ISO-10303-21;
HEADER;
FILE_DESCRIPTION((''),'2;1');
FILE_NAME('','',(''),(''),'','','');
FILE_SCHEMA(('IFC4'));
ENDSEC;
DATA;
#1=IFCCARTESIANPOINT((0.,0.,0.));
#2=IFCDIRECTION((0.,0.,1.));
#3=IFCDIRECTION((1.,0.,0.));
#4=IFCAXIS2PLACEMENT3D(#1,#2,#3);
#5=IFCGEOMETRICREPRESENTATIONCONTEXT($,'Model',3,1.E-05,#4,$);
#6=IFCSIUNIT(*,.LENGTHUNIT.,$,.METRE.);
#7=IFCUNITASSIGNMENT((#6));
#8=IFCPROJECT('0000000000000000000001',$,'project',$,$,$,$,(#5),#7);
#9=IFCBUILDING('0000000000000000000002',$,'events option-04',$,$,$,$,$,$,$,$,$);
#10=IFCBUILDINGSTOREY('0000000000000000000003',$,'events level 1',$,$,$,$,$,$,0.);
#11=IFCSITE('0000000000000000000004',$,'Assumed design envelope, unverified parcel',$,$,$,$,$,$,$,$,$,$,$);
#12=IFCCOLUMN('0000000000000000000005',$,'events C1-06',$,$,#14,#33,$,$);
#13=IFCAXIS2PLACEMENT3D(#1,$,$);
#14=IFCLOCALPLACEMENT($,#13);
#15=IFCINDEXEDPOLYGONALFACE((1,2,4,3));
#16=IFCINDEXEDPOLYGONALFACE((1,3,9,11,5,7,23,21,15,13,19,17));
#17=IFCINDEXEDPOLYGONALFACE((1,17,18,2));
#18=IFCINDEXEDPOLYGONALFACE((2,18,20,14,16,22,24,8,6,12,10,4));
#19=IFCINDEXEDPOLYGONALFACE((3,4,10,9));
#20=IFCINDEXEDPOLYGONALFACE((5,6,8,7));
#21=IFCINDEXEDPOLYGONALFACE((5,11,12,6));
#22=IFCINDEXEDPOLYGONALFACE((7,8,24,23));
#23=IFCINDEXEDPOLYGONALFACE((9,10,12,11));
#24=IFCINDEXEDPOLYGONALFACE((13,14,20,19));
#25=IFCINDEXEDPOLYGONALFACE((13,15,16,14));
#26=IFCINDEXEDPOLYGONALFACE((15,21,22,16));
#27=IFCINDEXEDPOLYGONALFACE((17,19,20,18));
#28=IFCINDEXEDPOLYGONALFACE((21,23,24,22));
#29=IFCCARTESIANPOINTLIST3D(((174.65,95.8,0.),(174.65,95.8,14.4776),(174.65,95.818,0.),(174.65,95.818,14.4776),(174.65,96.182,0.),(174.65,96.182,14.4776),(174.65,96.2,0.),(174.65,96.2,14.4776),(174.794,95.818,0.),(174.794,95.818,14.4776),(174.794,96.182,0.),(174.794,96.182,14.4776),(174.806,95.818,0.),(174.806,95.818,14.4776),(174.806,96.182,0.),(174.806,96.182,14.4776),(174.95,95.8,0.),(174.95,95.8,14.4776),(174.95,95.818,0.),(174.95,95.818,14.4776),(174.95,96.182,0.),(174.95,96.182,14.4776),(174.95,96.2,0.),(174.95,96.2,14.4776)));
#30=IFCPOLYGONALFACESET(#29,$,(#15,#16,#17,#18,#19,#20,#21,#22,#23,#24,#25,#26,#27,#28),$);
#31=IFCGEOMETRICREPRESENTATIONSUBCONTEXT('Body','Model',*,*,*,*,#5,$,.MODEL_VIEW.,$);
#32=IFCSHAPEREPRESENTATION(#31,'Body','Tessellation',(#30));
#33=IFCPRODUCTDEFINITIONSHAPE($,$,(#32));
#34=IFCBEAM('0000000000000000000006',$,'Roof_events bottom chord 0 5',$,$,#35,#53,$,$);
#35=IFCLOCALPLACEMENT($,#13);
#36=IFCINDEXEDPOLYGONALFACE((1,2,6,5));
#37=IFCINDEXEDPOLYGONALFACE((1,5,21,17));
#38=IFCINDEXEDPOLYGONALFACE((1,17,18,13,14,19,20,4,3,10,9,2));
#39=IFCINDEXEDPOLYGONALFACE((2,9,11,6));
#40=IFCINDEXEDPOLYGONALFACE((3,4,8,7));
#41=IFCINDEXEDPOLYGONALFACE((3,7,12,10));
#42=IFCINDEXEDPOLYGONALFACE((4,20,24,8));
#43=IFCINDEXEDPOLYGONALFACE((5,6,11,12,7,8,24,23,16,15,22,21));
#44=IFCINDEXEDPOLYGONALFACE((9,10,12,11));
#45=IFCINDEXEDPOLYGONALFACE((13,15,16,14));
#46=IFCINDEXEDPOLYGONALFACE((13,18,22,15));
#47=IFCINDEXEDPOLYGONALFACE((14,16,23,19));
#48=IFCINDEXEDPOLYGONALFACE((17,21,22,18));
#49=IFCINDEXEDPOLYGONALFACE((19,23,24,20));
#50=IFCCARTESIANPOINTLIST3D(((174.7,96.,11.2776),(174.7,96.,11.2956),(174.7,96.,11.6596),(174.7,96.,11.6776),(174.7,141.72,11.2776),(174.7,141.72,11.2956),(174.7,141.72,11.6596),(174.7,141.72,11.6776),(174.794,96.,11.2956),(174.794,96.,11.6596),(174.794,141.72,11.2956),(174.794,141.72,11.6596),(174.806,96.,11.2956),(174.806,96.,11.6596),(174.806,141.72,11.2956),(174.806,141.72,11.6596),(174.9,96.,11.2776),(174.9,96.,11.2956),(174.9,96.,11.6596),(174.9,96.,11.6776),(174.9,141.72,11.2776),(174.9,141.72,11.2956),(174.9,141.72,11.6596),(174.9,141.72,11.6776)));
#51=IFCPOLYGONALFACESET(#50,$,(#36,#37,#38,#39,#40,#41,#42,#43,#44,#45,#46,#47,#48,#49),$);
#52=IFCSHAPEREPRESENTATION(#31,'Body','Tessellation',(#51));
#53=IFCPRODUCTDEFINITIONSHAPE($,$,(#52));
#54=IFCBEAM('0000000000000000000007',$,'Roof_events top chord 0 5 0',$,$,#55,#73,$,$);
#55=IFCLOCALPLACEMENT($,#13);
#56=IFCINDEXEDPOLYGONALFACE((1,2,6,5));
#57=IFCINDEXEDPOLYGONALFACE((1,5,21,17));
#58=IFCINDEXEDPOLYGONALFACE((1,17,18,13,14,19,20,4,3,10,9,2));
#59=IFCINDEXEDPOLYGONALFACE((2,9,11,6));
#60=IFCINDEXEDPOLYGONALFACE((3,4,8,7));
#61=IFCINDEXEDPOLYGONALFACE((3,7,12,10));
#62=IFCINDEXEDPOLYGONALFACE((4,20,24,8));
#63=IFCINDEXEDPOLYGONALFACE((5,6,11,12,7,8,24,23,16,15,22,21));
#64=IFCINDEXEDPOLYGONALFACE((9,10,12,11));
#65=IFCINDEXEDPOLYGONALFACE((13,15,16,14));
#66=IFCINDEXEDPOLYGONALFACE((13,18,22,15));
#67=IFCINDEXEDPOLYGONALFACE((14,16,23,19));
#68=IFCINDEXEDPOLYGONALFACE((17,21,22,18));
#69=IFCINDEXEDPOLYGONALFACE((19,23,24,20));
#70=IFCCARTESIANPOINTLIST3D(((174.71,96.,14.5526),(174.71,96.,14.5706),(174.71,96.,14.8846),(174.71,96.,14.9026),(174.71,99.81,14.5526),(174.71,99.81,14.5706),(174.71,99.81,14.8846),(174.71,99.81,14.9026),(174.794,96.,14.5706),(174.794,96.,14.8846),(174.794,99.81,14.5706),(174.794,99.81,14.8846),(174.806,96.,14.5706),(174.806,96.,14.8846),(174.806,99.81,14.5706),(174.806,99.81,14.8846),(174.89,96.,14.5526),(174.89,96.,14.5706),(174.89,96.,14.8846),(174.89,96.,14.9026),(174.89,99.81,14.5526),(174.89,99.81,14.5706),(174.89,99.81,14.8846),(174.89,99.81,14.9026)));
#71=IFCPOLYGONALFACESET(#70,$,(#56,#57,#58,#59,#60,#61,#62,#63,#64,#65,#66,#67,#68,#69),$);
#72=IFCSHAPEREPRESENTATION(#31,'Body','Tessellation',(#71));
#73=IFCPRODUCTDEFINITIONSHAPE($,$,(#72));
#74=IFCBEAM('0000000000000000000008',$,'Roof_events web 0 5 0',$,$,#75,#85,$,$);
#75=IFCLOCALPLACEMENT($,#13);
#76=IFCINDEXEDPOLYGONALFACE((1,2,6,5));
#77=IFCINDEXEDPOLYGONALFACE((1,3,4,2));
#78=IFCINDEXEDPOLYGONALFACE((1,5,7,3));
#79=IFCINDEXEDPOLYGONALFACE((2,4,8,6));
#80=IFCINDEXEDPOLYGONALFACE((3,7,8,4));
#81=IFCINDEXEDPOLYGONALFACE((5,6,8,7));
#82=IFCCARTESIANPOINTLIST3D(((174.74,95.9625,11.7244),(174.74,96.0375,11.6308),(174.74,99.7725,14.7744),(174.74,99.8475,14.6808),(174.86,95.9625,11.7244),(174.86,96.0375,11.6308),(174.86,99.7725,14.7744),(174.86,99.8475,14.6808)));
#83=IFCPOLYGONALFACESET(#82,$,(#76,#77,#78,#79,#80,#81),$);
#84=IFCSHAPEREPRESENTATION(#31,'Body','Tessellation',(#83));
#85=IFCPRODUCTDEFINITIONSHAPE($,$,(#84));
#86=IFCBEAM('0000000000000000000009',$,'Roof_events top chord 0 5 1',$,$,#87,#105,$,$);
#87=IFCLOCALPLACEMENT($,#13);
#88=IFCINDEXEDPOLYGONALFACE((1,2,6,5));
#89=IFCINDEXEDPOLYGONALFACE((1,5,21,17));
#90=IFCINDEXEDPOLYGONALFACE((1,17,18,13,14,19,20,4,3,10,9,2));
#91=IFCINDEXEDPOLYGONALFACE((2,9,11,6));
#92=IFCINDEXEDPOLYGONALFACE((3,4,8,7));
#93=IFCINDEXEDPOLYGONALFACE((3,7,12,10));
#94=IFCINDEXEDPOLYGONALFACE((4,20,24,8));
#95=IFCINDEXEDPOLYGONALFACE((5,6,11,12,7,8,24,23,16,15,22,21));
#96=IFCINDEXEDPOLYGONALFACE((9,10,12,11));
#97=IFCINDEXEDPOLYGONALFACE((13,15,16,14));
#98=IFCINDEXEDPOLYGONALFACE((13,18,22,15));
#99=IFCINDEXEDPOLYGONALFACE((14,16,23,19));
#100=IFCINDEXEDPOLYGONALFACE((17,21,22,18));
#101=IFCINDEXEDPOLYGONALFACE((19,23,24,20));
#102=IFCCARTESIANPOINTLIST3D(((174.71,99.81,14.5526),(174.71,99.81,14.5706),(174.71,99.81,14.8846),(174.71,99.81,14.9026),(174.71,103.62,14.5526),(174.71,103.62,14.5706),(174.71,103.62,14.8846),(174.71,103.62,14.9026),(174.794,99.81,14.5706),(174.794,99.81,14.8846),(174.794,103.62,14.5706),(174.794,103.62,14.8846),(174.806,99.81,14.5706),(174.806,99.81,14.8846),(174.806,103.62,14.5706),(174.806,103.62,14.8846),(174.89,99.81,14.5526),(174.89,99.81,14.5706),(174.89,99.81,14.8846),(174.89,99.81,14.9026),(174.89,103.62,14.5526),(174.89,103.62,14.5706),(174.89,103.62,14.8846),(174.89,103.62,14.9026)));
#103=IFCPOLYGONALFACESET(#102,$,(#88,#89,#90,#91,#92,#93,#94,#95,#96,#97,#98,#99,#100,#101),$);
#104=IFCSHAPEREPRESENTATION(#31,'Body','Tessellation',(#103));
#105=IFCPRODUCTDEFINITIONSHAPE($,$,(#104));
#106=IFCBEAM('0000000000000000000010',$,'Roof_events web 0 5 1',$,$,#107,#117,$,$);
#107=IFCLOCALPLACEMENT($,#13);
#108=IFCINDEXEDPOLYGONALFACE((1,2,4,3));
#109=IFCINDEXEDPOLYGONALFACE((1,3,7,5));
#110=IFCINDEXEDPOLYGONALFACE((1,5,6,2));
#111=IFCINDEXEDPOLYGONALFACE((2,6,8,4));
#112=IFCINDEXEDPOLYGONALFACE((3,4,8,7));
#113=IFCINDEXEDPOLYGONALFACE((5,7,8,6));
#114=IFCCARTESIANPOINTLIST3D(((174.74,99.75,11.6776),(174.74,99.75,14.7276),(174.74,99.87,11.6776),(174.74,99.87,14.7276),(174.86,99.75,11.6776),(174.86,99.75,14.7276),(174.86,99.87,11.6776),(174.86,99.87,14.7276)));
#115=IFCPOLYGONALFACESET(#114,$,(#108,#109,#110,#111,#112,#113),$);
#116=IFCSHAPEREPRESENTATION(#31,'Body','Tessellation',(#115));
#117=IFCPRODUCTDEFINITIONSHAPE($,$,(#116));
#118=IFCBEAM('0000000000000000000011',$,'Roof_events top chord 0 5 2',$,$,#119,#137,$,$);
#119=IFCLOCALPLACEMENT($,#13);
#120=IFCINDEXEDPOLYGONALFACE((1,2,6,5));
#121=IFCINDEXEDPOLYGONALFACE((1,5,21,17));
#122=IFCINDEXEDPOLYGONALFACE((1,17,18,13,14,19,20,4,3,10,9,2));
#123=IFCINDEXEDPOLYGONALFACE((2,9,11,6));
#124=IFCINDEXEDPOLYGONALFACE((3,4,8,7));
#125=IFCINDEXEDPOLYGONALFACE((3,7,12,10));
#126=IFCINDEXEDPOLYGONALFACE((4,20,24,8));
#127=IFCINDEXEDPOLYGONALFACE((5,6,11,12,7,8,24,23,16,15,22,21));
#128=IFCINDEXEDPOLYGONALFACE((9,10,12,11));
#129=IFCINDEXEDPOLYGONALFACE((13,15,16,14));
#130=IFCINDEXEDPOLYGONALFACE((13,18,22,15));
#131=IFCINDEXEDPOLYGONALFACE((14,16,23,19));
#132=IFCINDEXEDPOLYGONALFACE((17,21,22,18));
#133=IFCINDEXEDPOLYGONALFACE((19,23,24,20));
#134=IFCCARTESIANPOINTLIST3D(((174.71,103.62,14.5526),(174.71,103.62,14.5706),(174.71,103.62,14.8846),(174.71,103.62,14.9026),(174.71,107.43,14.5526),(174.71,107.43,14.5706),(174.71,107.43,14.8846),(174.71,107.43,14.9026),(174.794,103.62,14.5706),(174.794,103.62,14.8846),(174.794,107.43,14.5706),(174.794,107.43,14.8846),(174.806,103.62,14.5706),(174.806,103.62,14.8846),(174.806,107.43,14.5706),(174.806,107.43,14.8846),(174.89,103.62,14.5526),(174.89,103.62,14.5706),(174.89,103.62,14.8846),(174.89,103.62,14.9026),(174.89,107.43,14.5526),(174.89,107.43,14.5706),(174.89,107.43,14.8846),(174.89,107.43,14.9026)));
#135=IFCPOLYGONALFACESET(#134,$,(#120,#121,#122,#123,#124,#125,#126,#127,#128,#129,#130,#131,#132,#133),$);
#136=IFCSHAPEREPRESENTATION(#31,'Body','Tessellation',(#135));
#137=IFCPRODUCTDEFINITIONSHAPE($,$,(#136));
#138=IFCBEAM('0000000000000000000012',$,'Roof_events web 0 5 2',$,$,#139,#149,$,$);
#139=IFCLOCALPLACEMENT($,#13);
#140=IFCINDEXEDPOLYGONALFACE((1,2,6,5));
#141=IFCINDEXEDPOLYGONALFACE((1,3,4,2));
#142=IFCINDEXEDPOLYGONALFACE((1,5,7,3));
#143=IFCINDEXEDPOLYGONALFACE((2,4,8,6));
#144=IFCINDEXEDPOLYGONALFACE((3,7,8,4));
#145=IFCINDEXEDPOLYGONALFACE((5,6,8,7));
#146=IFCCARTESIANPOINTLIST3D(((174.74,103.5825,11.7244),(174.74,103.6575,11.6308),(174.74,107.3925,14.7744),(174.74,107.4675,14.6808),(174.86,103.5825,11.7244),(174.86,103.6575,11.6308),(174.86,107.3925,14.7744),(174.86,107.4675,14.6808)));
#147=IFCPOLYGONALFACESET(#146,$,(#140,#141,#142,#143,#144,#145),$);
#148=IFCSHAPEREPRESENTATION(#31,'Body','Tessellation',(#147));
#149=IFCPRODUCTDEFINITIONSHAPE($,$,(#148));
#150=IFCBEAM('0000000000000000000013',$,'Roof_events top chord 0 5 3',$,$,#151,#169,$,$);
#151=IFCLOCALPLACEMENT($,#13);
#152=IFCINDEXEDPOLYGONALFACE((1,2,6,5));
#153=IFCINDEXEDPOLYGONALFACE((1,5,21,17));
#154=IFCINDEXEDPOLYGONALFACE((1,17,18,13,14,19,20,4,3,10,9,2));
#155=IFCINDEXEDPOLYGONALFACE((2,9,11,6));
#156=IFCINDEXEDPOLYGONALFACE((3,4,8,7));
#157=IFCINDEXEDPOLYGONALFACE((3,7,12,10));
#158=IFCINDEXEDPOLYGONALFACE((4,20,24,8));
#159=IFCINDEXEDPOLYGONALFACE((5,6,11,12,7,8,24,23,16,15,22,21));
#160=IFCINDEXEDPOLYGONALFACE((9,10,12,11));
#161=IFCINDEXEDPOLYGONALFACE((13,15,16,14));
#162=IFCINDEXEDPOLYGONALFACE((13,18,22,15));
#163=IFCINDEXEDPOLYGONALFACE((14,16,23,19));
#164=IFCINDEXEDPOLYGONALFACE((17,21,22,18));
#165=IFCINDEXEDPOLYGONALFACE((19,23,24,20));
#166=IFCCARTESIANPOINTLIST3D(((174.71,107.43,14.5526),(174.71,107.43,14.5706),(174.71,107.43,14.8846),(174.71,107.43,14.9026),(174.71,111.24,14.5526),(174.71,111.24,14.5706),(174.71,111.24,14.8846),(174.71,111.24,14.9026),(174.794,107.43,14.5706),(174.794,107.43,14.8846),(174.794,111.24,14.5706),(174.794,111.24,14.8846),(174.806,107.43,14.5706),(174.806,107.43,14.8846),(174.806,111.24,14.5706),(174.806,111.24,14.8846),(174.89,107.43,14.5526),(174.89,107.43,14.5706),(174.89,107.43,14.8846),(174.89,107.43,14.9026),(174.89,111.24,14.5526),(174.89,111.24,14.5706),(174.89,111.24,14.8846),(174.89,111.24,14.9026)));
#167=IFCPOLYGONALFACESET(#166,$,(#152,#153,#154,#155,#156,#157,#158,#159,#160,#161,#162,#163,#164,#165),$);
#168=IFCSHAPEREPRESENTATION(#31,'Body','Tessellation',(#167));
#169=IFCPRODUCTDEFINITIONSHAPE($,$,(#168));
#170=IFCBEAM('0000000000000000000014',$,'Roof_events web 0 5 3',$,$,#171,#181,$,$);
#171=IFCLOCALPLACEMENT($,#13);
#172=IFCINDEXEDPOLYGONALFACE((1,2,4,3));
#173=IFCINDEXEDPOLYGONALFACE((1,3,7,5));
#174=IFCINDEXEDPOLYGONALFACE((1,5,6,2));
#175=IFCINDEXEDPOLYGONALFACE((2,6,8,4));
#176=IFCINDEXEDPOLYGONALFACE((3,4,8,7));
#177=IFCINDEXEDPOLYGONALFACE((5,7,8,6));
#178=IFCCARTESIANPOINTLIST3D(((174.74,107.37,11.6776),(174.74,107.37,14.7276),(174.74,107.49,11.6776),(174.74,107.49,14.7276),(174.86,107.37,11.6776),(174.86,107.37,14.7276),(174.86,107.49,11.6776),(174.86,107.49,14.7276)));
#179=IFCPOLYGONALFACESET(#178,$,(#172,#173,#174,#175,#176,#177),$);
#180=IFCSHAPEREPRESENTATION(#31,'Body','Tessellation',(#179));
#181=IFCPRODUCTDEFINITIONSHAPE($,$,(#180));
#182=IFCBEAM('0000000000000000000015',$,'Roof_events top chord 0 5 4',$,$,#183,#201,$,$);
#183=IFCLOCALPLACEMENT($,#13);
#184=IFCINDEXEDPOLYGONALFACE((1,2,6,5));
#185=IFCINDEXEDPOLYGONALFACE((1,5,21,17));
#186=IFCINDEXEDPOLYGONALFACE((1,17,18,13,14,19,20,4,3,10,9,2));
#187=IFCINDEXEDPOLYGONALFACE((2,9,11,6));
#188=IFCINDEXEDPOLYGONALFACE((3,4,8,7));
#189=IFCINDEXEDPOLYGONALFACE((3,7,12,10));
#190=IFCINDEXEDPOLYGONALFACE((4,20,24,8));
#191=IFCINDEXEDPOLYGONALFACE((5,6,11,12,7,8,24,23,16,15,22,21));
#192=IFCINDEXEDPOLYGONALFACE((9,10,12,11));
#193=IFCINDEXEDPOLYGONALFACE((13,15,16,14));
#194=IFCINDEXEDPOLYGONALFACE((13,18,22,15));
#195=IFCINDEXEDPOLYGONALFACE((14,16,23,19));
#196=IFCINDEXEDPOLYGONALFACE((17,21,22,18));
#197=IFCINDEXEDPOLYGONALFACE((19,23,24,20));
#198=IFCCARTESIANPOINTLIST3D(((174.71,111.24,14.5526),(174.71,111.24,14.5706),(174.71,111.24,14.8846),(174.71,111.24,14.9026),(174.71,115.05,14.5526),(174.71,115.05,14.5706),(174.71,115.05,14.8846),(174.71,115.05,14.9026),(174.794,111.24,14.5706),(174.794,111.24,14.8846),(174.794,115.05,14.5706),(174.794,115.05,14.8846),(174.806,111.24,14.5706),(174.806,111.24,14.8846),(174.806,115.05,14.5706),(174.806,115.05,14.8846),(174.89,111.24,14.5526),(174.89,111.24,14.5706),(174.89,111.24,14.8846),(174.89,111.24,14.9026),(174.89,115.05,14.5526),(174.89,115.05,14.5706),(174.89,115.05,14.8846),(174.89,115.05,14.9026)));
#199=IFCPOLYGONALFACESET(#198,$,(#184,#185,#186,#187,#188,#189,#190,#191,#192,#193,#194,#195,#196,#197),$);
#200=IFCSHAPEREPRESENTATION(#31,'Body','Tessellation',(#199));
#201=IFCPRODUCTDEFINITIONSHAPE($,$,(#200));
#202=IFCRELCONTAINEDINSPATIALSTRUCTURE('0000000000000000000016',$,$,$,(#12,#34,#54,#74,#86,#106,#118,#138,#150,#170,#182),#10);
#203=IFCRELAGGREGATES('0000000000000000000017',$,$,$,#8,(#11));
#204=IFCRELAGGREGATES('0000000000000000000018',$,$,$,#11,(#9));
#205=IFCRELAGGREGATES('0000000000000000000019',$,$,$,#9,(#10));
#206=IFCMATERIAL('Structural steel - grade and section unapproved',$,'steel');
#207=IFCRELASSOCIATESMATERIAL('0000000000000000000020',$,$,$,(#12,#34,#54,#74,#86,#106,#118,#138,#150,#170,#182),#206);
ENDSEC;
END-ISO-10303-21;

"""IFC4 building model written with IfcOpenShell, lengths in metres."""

from ifc_helpers import new_model, si_unit, frame, origin_with_axes, place, context, subcontext, project, spatial, rectangle, i_section, extrude, material, element, save


model = new_model("IFC4")

# Units and contexts
model_context = context("Model", 3, precision=1e-05, world=origin_with_axes())
body_context = subcontext(model_context, "Body", "Model", "MODEL_VIEW")
ifc_project = project(units=[si_unit("LENGTHUNIT", "METRE")], contexts=[model_context])

# Site, building, storey
site = spatial("IfcSite", under=ifc_project, Name="Assumed design envelope, unverified parcel")
building = spatial("IfcBuilding", under=site, Name="events option-04")
storey = spatial("IfcBuildingStorey", under=building, Name="events level 1", Elevation=0.0)

# Column
ifc_material_1 = material(Name="Structural steel - grade and section unapproved", Category="steel")
column_placement = place(None, frame((174.8, 96.0, 0.0), z_axis=(0.0, 0.0, 1.0), x_axis=(-1.0, 0.0, 0.0)))
element("IfcColumn", 1, at=column_placement, inside=storey, material=ifc_material_1, Name="events C1-06", context=body_context, shape_type="SweptSolid", body=[
    extrude(i_section(OverallWidth=0.3, OverallDepth=0.4, WebThickness=0.012, FlangeThickness=0.018, FilletRadius=0.0), origin_with_axes(), (0.0, 0.0, 1.0), 14.4776),
])

# Beams
beam_1_placement = place(None, frame((174.8, 96.0, 11.4776), z_axis=(0.0, 1.0, 0.0), x_axis=(-1.0, 0.0, 0.0)))
element("IfcBeam", 2, at=beam_1_placement, inside=storey, material=ifc_material_1, Name="Roof_events bottom chord 0 5", context=body_context, shape_type="SweptSolid", body=[
    extrude(i_section(OverallWidth=0.2, OverallDepth=0.4, WebThickness=0.012, FlangeThickness=0.018, FilletRadius=0.0), origin_with_axes(), (0.0, 0.0, 1.0), 45.72),
])
beam_2_placement = place(None, frame((174.8, 96.0, 14.7276), z_axis=(0.0, 1.0, 0.0), x_axis=(-1.0, 0.0, 0.0)))
element("IfcBeam", 3, at=beam_2_placement, inside=storey, material=ifc_material_1, Name="Roof_events top chord 0 5 0", context=body_context, shape_type="SweptSolid", body=[
    extrude(i_section(OverallWidth=0.18, OverallDepth=0.35, WebThickness=0.012, FlangeThickness=0.018, FilletRadius=0.0), origin_with_axes(), (0.0, 0.0, 1.0), 3.81),
])
beam_3_placement = place(None, frame((174.8, 96.0, 11.6776), z_axis=(0.0, 0.780669, 0.624945), x_axis=(-1.0, 0.0, 0.0)))
element("IfcBeam", 4, at=beam_3_placement, inside=storey, material=ifc_material_1, Name="Roof_events web 0 5 0", context=body_context, shape_type="SweptSolid", body=[
    extrude(rectangle(XDim=0.12, YDim=0.12), origin_with_axes(), (0.0, 0.0, 1.0), 4.8804),
])
beam_4_placement = place(None, frame((174.8, 99.81, 14.7276), z_axis=(0.0, 1.0, 0.0), x_axis=(-1.0, 0.0, 0.0)))
element("IfcBeam", 5, at=beam_4_placement, inside=storey, material=ifc_material_1, Name="Roof_events top chord 0 5 1", context=body_context, shape_type="SweptSolid", body=[
    extrude(i_section(OverallWidth=0.18, OverallDepth=0.35, WebThickness=0.012, FlangeThickness=0.018, FilletRadius=0.0), origin_with_axes(), (0.0, 0.0, 1.0), 3.81),
])
beam_5_placement = place(None, frame((174.8, 99.81, 11.6776), z_axis=(0.0, 0.0, 1.0), x_axis=(-1.0, 0.0, 0.0)))
element("IfcBeam", 6, at=beam_5_placement, inside=storey, material=ifc_material_1, Name="Roof_events web 0 5 1", context=body_context, shape_type="SweptSolid", body=[
    extrude(rectangle(XDim=0.12, YDim=0.12), origin_with_axes(), (0.0, 0.0, 1.0), 3.05),
])
beam_6_placement = place(None, frame((174.8, 103.62, 14.7276), z_axis=(0.0, 1.0, 0.0), x_axis=(-1.0, 0.0, 0.0)))
element("IfcBeam", 7, at=beam_6_placement, inside=storey, material=ifc_material_1, Name="Roof_events top chord 0 5 2", context=body_context, shape_type="SweptSolid", body=[
    extrude(i_section(OverallWidth=0.18, OverallDepth=0.35, WebThickness=0.012, FlangeThickness=0.018, FilletRadius=0.0), origin_with_axes(), (0.0, 0.0, 1.0), 3.81),
])
beam_7_placement = place(None, frame((174.8, 103.62, 11.6776), z_axis=(0.0, 0.780669, 0.624945), x_axis=(-1.0, 0.0, 0.0)))
element("IfcBeam", 8, at=beam_7_placement, inside=storey, material=ifc_material_1, Name="Roof_events web 0 5 2", context=body_context, shape_type="SweptSolid", body=[
    extrude(rectangle(XDim=0.12, YDim=0.12), origin_with_axes(), (0.0, 0.0, 1.0), 4.8804),
])
beam_8_placement = place(None, frame((174.8, 107.43, 14.7276), z_axis=(0.0, 1.0, 0.0), x_axis=(-1.0, 0.0, 0.0)))
element("IfcBeam", 9, at=beam_8_placement, inside=storey, material=ifc_material_1, Name="Roof_events top chord 0 5 3", context=body_context, shape_type="SweptSolid", body=[
    extrude(i_section(OverallWidth=0.18, OverallDepth=0.35, WebThickness=0.012, FlangeThickness=0.018, FilletRadius=0.0), origin_with_axes(), (0.0, 0.0, 1.0), 3.81),
])
beam_9_placement = place(None, frame((174.8, 107.43, 11.6776), z_axis=(0.0, 0.0, 1.0), x_axis=(-1.0, 0.0, 0.0)))
element("IfcBeam", 10, at=beam_9_placement, inside=storey, material=ifc_material_1, Name="Roof_events web 0 5 3", context=body_context, shape_type="SweptSolid", body=[
    extrude(rectangle(XDim=0.12, YDim=0.12), origin_with_axes(), (0.0, 0.0, 1.0), 3.05),
])
beam_10_placement = place(None, frame((174.8, 111.24, 14.7276), z_axis=(0.0, 1.0, 0.0), x_axis=(-1.0, 0.0, 0.0)))
element("IfcBeam", 11, at=beam_10_placement, inside=storey, material=ifc_material_1, Name="Roof_events top chord 0 5 4", context=body_context, shape_type="SweptSolid", body=[
    extrude(i_section(OverallWidth=0.18, OverallDepth=0.35, WebThickness=0.012, FlangeThickness=0.018, FilletRadius=0.0), origin_with_axes(), (0.0, 0.0, 1.0), 3.81),
])

save(model, "model.ifc")
